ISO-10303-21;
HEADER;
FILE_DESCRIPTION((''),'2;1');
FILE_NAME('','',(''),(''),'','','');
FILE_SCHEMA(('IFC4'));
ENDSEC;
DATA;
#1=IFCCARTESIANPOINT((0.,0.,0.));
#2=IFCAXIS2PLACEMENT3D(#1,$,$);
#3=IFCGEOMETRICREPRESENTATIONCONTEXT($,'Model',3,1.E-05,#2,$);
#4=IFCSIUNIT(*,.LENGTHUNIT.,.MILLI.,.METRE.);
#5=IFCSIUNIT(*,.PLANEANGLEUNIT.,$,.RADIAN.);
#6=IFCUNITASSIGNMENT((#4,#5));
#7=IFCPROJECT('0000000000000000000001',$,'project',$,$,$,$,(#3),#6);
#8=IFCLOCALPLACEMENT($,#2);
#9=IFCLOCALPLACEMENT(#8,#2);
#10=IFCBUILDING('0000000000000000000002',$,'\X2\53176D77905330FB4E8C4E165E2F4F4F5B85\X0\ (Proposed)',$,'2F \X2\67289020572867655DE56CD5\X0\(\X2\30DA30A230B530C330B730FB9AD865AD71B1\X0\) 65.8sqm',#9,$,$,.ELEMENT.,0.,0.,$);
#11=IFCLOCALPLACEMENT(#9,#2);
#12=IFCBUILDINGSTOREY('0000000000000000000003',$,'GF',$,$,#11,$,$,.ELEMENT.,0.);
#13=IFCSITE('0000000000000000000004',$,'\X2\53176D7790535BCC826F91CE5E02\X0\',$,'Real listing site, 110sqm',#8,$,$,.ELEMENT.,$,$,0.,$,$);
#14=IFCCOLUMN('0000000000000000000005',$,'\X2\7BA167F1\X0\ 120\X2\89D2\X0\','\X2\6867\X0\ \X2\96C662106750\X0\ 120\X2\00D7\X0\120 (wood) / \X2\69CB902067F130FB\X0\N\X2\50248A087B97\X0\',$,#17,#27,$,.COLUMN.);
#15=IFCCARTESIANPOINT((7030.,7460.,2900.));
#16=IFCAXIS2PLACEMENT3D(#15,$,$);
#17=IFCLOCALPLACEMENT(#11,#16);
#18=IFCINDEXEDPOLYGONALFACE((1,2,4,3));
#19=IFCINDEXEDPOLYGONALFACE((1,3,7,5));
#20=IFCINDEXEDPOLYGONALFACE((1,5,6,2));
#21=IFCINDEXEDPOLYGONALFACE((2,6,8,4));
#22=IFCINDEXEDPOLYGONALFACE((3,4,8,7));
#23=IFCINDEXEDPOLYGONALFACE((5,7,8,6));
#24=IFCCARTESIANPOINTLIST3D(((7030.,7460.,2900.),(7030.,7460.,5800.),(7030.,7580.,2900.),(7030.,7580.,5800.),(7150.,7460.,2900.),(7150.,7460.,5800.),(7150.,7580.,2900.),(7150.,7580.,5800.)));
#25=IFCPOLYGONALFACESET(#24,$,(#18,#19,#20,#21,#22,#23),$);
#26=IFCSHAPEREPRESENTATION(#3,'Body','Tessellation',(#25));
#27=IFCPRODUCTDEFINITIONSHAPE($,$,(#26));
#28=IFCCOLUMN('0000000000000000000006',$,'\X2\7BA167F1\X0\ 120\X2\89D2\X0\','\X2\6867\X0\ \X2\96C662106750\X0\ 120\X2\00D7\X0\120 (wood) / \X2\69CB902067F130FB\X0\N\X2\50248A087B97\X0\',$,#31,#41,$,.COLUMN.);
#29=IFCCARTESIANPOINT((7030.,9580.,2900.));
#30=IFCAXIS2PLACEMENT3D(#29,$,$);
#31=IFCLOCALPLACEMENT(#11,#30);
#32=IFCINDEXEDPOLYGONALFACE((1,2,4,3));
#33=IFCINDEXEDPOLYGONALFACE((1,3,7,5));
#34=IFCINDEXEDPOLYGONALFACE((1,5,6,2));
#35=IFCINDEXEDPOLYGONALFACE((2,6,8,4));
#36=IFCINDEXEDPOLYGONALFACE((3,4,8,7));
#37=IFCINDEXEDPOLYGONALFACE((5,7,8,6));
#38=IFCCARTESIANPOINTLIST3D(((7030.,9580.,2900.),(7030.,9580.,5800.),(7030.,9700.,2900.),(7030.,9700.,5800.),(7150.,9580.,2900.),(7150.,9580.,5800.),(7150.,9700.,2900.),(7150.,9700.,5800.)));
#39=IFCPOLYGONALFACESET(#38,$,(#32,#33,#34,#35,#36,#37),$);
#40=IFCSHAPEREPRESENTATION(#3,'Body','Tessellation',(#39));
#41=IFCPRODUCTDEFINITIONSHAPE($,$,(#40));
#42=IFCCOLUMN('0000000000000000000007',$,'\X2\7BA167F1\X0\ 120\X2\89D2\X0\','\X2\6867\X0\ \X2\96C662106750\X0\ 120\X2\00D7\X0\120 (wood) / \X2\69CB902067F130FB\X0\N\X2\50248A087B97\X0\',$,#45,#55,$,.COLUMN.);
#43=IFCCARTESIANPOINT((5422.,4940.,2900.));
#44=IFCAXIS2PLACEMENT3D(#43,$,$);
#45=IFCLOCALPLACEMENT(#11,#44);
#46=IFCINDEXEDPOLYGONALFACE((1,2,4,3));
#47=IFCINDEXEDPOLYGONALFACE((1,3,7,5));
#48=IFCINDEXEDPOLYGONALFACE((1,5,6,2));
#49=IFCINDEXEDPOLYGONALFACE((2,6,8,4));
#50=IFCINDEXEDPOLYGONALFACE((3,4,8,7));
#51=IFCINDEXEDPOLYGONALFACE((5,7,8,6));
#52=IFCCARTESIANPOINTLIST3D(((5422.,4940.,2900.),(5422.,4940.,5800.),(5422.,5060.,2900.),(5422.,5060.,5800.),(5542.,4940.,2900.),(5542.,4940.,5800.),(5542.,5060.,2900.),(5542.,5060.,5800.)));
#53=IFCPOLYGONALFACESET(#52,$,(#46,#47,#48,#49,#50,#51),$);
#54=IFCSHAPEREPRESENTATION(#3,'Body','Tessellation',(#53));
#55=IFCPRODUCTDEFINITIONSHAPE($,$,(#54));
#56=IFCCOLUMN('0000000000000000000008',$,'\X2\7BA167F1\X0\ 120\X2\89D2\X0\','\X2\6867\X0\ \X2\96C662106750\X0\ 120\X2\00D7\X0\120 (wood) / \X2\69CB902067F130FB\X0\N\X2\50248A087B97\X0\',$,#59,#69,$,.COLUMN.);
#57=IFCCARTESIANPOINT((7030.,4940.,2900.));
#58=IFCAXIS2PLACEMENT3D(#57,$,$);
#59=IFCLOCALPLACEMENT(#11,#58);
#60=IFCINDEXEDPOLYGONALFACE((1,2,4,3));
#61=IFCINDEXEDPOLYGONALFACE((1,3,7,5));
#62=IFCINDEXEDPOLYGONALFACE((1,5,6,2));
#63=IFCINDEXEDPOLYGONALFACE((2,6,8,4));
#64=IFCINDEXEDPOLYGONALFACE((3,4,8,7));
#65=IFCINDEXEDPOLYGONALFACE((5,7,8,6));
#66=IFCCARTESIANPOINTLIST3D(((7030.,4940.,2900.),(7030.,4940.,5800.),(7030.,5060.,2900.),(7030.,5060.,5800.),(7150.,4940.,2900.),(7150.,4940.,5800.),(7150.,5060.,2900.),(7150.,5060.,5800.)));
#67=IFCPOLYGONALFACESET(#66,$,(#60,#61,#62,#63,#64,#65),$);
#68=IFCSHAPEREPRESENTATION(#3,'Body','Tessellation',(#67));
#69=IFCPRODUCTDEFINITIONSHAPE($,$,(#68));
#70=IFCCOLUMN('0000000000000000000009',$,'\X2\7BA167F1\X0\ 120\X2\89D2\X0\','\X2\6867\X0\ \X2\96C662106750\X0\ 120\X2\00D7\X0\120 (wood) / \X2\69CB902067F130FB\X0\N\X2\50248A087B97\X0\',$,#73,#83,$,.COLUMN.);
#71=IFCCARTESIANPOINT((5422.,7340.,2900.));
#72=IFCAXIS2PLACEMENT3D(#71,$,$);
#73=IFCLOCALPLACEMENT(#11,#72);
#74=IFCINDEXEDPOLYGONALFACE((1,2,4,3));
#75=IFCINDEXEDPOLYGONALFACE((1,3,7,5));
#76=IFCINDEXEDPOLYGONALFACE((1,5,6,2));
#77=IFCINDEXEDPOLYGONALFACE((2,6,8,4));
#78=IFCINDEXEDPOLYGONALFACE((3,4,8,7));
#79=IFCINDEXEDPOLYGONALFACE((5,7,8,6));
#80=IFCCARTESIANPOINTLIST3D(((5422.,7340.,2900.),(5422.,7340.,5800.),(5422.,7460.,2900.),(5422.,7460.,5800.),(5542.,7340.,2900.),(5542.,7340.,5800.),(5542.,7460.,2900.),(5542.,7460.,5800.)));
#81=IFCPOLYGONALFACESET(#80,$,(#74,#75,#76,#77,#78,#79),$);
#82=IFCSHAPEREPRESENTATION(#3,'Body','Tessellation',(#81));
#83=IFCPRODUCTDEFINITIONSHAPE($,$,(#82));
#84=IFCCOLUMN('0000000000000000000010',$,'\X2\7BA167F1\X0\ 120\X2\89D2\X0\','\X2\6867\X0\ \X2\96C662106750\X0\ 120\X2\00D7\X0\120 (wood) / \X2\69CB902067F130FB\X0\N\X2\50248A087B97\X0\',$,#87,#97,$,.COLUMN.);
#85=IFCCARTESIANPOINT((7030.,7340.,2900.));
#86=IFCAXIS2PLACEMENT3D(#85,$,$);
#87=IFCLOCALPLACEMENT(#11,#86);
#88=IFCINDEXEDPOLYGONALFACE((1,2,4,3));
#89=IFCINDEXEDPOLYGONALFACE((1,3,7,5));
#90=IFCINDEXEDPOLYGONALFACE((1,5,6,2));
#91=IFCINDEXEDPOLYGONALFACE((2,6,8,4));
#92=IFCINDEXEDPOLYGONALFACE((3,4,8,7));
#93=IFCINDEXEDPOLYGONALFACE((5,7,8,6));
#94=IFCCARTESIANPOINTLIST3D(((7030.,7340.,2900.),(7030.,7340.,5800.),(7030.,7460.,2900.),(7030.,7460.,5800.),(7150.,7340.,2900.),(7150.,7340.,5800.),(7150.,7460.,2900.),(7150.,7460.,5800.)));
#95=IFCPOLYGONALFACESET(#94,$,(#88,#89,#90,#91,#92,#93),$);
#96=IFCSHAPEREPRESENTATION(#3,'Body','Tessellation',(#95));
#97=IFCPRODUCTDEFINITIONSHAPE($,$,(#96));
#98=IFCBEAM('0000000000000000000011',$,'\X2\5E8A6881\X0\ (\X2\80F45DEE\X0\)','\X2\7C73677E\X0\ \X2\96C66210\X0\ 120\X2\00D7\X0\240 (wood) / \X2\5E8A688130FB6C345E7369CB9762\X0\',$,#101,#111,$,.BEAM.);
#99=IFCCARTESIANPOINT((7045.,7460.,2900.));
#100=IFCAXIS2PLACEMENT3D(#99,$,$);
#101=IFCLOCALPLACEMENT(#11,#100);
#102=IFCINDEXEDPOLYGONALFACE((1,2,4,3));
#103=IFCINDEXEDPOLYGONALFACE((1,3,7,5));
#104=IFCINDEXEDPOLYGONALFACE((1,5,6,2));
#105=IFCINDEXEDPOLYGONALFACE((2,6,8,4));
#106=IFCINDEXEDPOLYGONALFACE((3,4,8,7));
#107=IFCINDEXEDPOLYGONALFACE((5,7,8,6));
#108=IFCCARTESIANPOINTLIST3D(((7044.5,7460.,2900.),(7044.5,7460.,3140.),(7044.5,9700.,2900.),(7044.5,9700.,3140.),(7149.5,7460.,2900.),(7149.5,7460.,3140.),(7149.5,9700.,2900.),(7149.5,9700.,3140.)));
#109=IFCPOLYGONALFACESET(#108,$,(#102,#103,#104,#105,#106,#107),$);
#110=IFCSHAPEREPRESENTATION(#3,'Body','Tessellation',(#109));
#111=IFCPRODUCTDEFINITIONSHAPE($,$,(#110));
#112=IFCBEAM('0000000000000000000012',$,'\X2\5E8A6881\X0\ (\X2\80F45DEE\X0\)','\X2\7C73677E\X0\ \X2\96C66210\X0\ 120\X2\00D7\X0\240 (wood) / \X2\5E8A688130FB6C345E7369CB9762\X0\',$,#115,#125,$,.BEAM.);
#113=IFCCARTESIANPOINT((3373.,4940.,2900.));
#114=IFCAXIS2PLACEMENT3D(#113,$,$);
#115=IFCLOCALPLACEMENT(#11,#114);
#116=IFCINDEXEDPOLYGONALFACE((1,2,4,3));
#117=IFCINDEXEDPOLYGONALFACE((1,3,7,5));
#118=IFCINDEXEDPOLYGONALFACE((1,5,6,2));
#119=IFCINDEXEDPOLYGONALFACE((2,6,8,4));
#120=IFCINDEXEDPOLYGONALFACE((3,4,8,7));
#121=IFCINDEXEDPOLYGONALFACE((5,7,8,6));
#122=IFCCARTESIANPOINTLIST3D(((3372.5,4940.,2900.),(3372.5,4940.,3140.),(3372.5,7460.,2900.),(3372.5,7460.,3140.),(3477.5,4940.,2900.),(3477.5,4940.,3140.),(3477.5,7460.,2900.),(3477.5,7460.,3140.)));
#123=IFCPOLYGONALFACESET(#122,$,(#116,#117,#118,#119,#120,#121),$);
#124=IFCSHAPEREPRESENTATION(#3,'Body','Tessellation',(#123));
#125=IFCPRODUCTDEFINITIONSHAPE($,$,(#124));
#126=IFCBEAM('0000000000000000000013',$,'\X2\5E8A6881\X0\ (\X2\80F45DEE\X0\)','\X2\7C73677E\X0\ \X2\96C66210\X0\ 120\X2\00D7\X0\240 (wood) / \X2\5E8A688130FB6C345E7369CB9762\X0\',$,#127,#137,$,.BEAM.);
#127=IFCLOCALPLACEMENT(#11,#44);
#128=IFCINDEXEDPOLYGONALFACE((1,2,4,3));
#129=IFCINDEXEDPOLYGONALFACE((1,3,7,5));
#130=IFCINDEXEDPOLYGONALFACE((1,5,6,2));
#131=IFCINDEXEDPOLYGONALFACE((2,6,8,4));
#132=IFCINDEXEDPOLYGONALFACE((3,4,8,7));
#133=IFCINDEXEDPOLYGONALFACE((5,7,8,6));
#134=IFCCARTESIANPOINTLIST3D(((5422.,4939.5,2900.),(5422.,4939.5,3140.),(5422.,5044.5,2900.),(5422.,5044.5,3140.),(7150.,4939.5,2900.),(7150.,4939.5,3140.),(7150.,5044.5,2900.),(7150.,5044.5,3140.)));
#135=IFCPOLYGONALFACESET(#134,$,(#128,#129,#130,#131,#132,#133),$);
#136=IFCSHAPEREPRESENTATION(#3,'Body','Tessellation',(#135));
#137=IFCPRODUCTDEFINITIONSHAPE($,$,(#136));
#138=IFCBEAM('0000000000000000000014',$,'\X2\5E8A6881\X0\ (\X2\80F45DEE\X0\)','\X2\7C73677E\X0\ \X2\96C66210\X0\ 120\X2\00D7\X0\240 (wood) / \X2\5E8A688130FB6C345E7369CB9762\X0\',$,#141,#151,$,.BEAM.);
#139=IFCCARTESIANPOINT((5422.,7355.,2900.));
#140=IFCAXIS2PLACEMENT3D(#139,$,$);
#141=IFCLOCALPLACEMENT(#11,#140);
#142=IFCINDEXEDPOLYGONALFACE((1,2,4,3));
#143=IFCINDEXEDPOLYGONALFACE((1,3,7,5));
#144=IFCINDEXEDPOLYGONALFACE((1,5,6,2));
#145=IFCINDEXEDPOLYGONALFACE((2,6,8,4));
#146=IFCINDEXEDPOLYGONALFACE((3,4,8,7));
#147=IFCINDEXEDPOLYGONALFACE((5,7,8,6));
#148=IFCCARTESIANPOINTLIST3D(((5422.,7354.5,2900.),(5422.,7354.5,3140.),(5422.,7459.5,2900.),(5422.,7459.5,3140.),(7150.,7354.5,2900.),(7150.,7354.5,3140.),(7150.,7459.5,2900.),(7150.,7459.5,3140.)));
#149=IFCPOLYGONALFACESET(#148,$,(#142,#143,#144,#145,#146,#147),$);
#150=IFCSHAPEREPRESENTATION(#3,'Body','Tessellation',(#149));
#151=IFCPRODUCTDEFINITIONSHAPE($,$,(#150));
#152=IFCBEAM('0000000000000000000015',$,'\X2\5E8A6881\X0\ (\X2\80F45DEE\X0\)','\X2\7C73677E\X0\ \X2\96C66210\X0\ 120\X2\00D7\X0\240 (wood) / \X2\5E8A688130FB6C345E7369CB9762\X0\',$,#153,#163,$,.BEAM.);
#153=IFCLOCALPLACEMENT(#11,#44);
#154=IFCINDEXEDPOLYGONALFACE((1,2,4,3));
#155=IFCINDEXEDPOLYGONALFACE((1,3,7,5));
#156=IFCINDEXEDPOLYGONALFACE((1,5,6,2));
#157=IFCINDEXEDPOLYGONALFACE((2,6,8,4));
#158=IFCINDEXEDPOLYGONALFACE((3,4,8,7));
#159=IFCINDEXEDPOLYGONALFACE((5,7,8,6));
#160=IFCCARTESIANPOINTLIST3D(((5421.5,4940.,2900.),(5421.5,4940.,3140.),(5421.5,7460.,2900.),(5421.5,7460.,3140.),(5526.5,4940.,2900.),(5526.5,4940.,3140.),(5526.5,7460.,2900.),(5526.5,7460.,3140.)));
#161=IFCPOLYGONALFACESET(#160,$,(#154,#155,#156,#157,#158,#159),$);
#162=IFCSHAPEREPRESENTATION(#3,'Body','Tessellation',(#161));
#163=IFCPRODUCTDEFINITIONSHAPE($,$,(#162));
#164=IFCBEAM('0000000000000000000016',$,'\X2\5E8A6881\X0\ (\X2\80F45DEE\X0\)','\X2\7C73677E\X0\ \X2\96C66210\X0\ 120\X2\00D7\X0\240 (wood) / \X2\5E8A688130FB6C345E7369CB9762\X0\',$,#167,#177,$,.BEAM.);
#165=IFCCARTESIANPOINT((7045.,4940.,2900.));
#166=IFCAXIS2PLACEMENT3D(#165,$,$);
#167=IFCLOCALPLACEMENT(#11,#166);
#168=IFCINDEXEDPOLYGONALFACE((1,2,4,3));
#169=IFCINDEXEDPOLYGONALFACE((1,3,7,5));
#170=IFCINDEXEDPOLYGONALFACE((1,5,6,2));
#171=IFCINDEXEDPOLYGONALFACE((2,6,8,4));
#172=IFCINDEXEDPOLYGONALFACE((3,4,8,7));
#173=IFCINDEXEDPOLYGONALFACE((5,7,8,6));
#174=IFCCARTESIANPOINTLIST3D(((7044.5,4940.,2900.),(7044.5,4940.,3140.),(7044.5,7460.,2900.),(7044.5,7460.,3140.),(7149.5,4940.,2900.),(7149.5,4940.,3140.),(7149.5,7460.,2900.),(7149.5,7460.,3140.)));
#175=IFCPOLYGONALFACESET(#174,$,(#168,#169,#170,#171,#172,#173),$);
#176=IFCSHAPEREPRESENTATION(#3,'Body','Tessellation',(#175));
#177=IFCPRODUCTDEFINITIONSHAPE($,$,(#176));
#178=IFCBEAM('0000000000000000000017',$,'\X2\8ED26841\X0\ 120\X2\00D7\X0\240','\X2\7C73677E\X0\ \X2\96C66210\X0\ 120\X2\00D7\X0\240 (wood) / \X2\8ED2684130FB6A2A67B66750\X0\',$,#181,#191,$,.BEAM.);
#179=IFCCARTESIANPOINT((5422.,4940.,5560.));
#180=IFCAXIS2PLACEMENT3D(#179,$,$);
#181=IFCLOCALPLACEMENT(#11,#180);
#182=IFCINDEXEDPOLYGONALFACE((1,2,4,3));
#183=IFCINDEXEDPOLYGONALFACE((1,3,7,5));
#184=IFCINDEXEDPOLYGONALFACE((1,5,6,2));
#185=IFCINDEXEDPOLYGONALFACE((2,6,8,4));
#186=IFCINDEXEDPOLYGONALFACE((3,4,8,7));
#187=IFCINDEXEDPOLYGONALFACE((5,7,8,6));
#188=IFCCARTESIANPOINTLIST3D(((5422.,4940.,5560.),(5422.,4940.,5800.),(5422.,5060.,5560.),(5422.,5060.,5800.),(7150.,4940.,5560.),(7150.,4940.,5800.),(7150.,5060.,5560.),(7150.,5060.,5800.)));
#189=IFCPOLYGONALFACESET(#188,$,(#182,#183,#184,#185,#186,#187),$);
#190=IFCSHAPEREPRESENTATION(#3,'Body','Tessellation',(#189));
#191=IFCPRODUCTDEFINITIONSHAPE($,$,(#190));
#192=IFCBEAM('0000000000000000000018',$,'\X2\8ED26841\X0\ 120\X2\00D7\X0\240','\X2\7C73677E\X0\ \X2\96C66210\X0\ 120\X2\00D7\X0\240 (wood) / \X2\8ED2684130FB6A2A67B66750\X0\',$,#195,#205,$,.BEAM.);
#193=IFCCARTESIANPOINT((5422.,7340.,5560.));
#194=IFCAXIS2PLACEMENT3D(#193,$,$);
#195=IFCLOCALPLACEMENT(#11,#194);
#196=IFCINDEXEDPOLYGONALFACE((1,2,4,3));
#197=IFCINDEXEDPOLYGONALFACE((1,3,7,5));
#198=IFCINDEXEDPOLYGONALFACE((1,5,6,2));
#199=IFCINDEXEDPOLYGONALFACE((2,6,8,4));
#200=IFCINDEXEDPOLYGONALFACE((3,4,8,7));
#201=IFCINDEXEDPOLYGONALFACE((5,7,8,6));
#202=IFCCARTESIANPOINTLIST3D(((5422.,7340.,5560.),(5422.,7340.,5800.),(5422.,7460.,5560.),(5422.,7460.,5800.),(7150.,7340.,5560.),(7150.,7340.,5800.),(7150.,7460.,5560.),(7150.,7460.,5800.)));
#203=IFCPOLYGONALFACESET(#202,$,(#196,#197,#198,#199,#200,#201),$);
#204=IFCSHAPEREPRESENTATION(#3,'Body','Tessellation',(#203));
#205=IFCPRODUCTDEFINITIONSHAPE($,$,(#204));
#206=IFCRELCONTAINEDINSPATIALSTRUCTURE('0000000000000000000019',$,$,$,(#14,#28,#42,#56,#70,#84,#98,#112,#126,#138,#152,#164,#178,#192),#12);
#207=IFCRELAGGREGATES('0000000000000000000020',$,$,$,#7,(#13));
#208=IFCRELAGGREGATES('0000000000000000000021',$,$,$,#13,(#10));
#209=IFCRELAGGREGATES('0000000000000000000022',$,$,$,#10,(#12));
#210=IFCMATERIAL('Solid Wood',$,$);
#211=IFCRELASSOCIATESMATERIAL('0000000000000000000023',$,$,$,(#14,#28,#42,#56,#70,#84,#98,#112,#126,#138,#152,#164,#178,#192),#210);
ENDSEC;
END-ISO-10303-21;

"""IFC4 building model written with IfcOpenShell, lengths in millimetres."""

from ifc_helpers import new_model, si_unit, frame, frame_2d, origin, place, context, project, spatial, rectangle, extrude, material, element, save


model = new_model("IFC4")

# Units and contexts
model_context = context("Model", 3, precision=1e-05, world=origin())
ifc_project = project(units=[si_unit("LENGTHUNIT", "METRE", prefix="MILLI"), si_unit("PLANEANGLEUNIT", "RADIAN")], contexts=[model_context])

# Site, building, storey
site_placement = place(None, origin())
site = spatial("IfcSite", under=ifc_project, at=site_placement, Name="北海道富良野市", ObjectType="Real listing site, 110sqm", CompositionType="ELEMENT", RefElevation=0.0)
building_placement = place(site_placement, origin())
building = spatial("IfcBuilding", under=site, at=building_placement, Name="北海道・二世帯住宅 (Proposed)", ObjectType="2F 木造在来工法(ペアサッシ・高断熱) 65.8sqm", CompositionType="ELEMENT", ElevationOfRefHeight=0.0, ElevationOfTerrain=0.0)
storey_placement = place(building_placement, origin())
storey = spatial("IfcBuildingStorey", under=building, at=storey_placement, Name="GF", CompositionType="ELEMENT", Elevation=0.0)

# Columns
ifc_material_1 = material(Name="Solid Wood")
column_1_placement = place(storey_placement, frame((7030.0, 7460.0, 2900.0)))
element("IfcColumn", 1, at=column_1_placement, inside=storey, material=ifc_material_1, Name="管柱 120角", Description="桧 集成材 120×120 (wood) / 構造柱・N値計算", PredefinedType="COLUMN", context=model_context, shape_type="SweptSolid", body=[
    extrude(rectangle(XDim=120.0, YDim=120.0, at=frame_2d((60.0, 60.0))), frame((7030.0, 7460.0, 2900.0)), (0.0, 0.0, 1.0), 2900.0),
])
column_2_placement = place(storey_placement, frame((7030.0, 9580.0, 2900.0)))
element("IfcColumn", 2, at=column_2_placement, inside=storey, material=ifc_material_1, Name="管柱 120角", Description="桧 集成材 120×120 (wood) / 構造柱・N値計算", PredefinedType="COLUMN", context=model_context, shape_type="SweptSolid", body=[
    extrude(rectangle(XDim=120.0, YDim=120.0, at=frame_2d((60.0, 60.0))), frame((7030.0, 9580.0, 2900.0)), (0.0, 0.0, 1.0), 2900.0),
])
column_3_placement = place(storey_placement, frame((5422.0, 4940.0, 2900.0)))
element("IfcColumn", 3, at=column_3_placement, inside=storey, material=ifc_material_1, Name="管柱 120角", Description="桧 集成材 120×120 (wood) / 構造柱・N値計算", PredefinedType="COLUMN", context=model_context, shape_type="SweptSolid", body=[
    extrude(rectangle(XDim=120.0, YDim=120.0, at=frame_2d((60.0, 60.0))), frame((5422.0, 4940.0, 2900.0)), (0.0, 0.0, 1.0), 2900.0),
])
column_4_placement = place(storey_placement, frame((7030.0, 4940.0, 2900.0)))
element("IfcColumn", 4, at=column_4_placement, inside=storey, material=ifc_material_1, Name="管柱 120角", Description="桧 集成材 120×120 (wood) / 構造柱・N値計算", PredefinedType="COLUMN", context=model_context, shape_type="SweptSolid", body=[
    extrude(rectangle(XDim=120.0, YDim=120.0, at=frame_2d((60.0, 60.0))), frame((7030.0, 4940.0, 2900.0)), (0.0, 0.0, 1.0), 2900.0),
])
column_5_placement = place(storey_placement, frame((5422.0, 7340.0, 2900.0)))
element("IfcColumn", 5, at=column_5_placement, inside=storey, material=ifc_material_1, Name="管柱 120角", Description="桧 集成材 120×120 (wood) / 構造柱・N値計算", PredefinedType="COLUMN", context=model_context, shape_type="SweptSolid", body=[
    extrude(rectangle(XDim=120.0, YDim=120.0, at=frame_2d((60.0, 60.0))), frame((5422.0, 7340.0, 2900.0)), (0.0, 0.0, 1.0), 2900.0),
])
column_6_placement = place(storey_placement, frame((7030.0, 7340.0, 2900.0)))
element("IfcColumn", 6, at=column_6_placement, inside=storey, material=ifc_material_1, Name="管柱 120角", Description="桧 集成材 120×120 (wood) / 構造柱・N値計算", PredefinedType="COLUMN", context=model_context, shape_type="SweptSolid", body=[
    extrude(rectangle(XDim=120.0, YDim=120.0, at=frame_2d((60.0, 60.0))), frame((7030.0, 7340.0, 2900.0)), (0.0, 0.0, 1.0), 2900.0),
])

# Beams
beam_1_placement = place(storey_placement, frame((7045.0, 7460.0, 2900.0)))
element("IfcBeam", 7, at=beam_1_placement, inside=storey, material=ifc_material_1, Name="床梁 (胴差)", Description="米松 集成 120×240 (wood) / 床梁・水平構面", PredefinedType="BEAM", context=model_context, shape_type="SweptSolid", body=[
    extrude(rectangle(XDim=105.0, YDim=2240.0, at=frame_2d((52.0, 1120.0))), frame((7045.0, 7460.0, 2900.0)), (0.0, 0.0, 1.0), 240.0),
])
beam_2_placement = place(storey_placement, frame((3373.0, 4940.0, 2900.0)))
element("IfcBeam", 8, at=beam_2_placement, inside=storey, material=ifc_material_1, Name="床梁 (胴差)", Description="米松 集成 120×240 (wood) / 床梁・水平構面", PredefinedType="BEAM", context=model_context, shape_type="SweptSolid", body=[
    extrude(rectangle(XDim=105.0, YDim=2520.0, at=frame_2d((52.0, 1260.0))), frame((3373.0, 4940.0, 2900.0)), (0.0, 0.0, 1.0), 240.0),
])
beam_3_placement = place(storey_placement, frame((5422.0, 4940.0, 2900.0)))
element("IfcBeam", 9, at=beam_3_placement, inside=storey, material=ifc_material_1, Name="床梁 (胴差)", Description="米松 集成 120×240 (wood) / 床梁・水平構面", PredefinedType="BEAM", context=model_context, shape_type="SweptSolid", body=[
    extrude(rectangle(XDim=1728.0, YDim=105.0, at=frame_2d((864.0, 52.0))), frame((5422.0, 4940.0, 2900.0)), (0.0, 0.0, 1.0), 240.0),
])
beam_4_placement = place(storey_placement, frame((5422.0, 7355.0, 2900.0)))
element("IfcBeam", 10, at=beam_4_placement, inside=storey, material=ifc_material_1, Name="床梁 (胴差)", Description="米松 集成 120×240 (wood) / 床梁・水平構面", PredefinedType="BEAM", context=model_context, shape_type="SweptSolid", body=[
    extrude(rectangle(XDim=1728.0, YDim=105.0, at=frame_2d((864.0, 52.0))), frame((5422.0, 7355.0, 2900.0)), (0.0, 0.0, 1.0), 240.0),
])
beam_5_placement = place(storey_placement, frame((5422.0, 4940.0, 2900.0)))
element("IfcBeam", 11, at=beam_5_placement, inside=storey, material=ifc_material_1, Name="床梁 (胴差)", Description="米松 集成 120×240 (wood) / 床梁・水平構面", PredefinedType="BEAM", context=model_context, shape_type="SweptSolid", body=[
    extrude(rectangle(XDim=105.0, YDim=2520.0, at=frame_2d((52.0, 1260.0))), frame((5422.0, 4940.0, 2900.0)), (0.0, 0.0, 1.0), 240.0),
])
beam_6_placement = place(storey_placement, frame((7045.0, 4940.0, 2900.0)))
element("IfcBeam", 12, at=beam_6_placement, inside=storey, material=ifc_material_1, Name="床梁 (胴差)", Description="米松 集成 120×240 (wood) / 床梁・水平構面", PredefinedType="BEAM", context=model_context, shape_type="SweptSolid", body=[
    extrude(rectangle(XDim=105.0, YDim=2520.0, at=frame_2d((52.0, 1260.0))), frame((7045.0, 4940.0, 2900.0)), (0.0, 0.0, 1.0), 240.0),
])
beam_7_placement = place(storey_placement, frame((5422.0, 4940.0, 5560.0)))
element("IfcBeam", 13, at=beam_7_placement, inside=storey, material=ifc_material_1, Name="軒桁 120×240", Description="米松 集成 120×240 (wood) / 軒桁・横架材", PredefinedType="BEAM", context=model_context, shape_type="SweptSolid", body=[
    extrude(rectangle(XDim=1728.0, YDim=120.0, at=frame_2d((864.0, 60.0))), frame((5422.0, 4940.0, 5560.0)), (0.0, 0.0, 1.0), 240.0),
])
beam_8_placement = place(storey_placement, frame((5422.0, 7340.0, 5560.0)))
element("IfcBeam", 14, at=beam_8_placement, inside=storey, material=ifc_material_1, Name="軒桁 120×240", Description="米松 集成 120×240 (wood) / 軒桁・横架材", PredefinedType="BEAM", context=model_context, shape_type="SweptSolid", body=[
    extrude(rectangle(XDim=1728.0, YDim=120.0, at=frame_2d((864.0, 60.0))), frame((5422.0, 7340.0, 5560.0)), (0.0, 0.0, 1.0), 240.0),
])

save(model, "model.ifc")
